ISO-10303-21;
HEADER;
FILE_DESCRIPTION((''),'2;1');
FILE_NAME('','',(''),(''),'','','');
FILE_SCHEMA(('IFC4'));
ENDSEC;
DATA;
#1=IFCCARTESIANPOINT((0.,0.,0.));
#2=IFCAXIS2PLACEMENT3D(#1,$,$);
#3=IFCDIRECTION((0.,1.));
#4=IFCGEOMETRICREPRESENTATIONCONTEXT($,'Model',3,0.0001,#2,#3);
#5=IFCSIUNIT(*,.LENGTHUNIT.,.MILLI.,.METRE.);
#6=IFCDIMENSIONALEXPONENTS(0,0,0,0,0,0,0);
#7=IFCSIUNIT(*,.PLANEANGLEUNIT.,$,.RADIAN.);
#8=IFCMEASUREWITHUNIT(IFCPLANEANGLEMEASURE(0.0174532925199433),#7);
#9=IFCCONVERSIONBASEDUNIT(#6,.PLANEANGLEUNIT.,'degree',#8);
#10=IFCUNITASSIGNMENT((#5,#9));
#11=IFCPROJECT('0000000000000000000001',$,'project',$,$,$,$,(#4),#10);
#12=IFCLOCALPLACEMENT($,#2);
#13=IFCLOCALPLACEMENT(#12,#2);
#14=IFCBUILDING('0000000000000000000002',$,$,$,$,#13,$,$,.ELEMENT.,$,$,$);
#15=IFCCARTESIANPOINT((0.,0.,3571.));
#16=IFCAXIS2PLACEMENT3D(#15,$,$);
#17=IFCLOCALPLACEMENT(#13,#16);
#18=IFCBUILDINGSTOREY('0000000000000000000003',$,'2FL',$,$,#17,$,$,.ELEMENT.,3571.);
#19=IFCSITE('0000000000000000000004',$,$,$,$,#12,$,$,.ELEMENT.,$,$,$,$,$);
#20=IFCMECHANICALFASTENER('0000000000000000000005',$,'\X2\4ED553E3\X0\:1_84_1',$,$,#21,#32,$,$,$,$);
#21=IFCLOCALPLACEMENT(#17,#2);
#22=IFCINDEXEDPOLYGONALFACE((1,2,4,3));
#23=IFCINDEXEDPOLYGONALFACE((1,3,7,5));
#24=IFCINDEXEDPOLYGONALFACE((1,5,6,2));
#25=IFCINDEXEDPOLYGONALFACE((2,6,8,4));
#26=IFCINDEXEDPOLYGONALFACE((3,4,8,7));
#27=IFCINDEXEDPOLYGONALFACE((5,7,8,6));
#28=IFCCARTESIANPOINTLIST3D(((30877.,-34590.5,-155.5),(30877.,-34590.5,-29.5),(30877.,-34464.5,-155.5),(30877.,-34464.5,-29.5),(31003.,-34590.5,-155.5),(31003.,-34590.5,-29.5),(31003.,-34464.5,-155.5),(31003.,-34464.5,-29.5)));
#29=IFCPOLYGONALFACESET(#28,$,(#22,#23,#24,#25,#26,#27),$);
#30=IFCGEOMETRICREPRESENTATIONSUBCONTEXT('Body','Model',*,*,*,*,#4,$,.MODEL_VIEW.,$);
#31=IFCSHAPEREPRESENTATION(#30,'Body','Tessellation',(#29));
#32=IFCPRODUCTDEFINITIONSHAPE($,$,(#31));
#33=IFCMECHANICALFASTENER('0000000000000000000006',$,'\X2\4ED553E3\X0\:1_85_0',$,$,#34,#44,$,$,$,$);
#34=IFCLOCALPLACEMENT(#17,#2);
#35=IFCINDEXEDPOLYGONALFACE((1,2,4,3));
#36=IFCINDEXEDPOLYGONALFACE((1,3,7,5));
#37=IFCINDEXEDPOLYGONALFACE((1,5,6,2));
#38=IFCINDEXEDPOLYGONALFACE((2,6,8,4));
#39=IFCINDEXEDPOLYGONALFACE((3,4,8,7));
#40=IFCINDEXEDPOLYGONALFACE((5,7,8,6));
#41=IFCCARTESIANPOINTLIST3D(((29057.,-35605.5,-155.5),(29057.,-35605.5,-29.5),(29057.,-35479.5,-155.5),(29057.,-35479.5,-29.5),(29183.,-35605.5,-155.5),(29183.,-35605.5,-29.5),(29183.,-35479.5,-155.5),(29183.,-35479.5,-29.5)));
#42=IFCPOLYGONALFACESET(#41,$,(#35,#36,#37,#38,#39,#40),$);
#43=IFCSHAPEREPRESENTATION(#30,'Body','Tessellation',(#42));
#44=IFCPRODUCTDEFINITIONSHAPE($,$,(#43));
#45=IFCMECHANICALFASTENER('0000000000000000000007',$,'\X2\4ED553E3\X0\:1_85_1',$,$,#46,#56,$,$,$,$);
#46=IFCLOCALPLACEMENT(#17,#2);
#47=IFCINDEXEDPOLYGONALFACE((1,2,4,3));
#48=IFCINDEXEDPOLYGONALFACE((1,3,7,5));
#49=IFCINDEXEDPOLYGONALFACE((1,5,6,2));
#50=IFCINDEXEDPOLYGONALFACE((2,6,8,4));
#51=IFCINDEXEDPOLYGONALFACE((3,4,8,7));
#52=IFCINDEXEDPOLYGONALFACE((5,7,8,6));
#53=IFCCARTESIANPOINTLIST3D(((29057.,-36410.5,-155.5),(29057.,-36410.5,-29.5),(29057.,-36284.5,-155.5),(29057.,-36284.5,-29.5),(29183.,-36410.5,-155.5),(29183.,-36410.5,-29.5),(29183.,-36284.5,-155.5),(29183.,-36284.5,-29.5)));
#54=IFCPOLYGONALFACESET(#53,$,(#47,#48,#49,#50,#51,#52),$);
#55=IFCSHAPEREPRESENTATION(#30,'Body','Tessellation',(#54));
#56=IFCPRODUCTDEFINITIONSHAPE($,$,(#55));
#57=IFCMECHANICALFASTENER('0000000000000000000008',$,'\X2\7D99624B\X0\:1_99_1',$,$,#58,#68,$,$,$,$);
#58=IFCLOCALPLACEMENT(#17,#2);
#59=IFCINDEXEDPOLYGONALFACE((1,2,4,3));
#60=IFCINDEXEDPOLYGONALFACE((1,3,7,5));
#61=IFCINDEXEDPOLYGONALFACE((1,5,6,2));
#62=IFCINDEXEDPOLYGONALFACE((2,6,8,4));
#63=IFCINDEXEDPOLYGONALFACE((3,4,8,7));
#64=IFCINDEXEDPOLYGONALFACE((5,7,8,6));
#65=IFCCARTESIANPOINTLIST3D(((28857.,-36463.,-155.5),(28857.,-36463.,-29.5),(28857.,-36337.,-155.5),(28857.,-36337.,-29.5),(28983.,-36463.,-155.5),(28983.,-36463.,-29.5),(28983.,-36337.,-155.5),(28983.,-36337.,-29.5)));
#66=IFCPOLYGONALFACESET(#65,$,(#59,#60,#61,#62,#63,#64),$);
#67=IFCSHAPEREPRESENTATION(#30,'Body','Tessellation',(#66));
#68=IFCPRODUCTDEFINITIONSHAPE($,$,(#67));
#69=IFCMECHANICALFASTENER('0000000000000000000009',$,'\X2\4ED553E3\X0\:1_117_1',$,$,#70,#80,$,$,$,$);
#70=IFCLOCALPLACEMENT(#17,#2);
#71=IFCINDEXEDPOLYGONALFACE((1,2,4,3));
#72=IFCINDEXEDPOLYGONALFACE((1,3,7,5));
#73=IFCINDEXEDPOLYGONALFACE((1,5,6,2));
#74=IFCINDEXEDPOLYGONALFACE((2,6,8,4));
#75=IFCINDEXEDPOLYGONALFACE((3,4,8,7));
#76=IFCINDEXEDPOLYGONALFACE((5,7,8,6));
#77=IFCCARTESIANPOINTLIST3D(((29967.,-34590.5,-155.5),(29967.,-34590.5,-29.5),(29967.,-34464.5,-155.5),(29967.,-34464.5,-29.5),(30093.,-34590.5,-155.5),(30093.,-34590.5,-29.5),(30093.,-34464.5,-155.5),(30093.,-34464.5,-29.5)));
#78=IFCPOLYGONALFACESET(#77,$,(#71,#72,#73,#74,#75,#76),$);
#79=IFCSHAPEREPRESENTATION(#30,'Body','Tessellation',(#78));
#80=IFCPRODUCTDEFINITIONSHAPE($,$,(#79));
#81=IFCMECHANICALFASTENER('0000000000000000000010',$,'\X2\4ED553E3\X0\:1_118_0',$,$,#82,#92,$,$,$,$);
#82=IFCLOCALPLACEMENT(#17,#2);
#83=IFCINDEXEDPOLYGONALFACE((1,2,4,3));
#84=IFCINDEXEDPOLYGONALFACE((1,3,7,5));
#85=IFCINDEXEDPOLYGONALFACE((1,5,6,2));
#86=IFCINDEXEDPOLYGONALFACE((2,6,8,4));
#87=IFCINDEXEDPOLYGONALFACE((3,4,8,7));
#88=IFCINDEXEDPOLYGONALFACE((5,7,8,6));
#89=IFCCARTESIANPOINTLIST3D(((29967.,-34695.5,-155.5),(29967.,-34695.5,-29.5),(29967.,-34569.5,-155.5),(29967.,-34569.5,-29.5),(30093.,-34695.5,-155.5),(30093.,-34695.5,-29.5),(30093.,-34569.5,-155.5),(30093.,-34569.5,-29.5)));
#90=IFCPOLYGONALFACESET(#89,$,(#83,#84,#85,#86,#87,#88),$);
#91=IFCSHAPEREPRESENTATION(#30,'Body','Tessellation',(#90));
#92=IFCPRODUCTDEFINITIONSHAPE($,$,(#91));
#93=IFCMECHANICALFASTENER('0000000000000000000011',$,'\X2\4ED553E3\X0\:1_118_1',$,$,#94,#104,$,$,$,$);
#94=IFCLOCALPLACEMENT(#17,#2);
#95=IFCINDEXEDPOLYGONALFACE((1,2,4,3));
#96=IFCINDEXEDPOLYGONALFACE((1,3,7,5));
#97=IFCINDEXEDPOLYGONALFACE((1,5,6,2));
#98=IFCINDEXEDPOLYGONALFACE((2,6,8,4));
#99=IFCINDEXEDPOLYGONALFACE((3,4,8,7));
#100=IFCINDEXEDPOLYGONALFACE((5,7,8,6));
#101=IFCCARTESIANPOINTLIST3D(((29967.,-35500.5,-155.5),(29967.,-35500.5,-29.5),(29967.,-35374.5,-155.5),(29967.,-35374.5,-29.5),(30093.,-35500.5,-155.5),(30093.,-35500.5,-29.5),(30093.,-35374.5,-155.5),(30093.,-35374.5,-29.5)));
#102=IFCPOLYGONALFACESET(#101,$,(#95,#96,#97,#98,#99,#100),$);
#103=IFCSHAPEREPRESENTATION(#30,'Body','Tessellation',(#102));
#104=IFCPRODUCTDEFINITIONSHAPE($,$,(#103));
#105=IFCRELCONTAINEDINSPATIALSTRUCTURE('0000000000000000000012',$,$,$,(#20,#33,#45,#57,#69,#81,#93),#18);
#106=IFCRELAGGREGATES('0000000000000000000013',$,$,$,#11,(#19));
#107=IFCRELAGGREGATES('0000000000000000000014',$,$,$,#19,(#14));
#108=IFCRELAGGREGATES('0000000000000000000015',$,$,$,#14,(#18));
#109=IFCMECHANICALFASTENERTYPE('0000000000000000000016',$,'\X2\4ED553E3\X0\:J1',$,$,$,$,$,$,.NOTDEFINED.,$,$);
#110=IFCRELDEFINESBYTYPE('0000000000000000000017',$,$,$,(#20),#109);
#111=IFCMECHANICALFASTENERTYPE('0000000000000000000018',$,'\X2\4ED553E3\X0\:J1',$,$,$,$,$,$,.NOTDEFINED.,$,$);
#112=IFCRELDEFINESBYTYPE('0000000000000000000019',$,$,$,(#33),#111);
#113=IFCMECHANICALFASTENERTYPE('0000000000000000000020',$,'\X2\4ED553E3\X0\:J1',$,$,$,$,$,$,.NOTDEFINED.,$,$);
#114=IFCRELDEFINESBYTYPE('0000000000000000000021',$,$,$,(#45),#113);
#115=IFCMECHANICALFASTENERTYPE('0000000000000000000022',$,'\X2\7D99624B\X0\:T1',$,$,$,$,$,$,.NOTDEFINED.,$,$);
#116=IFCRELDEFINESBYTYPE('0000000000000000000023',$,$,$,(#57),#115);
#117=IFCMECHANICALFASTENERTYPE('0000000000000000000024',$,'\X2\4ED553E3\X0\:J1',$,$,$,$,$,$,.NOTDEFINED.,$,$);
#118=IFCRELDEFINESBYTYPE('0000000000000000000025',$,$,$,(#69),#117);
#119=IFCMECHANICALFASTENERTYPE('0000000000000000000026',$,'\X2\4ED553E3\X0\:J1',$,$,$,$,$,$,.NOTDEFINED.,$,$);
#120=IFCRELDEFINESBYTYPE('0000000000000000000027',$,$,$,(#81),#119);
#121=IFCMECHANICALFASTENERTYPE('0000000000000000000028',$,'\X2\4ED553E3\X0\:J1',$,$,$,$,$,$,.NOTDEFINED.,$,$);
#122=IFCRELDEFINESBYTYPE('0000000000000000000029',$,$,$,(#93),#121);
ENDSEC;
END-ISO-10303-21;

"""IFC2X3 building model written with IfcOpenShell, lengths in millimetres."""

from ifc_helpers import new_model, entity, si_unit, converted_unit, direction, frame, origin, origin_with_axes, origin_2d, place, context, subcontext, project, spatial, rectangle, extrude, type_object, element, save


model = new_model("IFC2X3")

# Units and contexts
model_context = context("Model", 3, precision=0.0001, world=origin(), true_north=direction((0.0, 1.0)))
body_context = subcontext(model_context, "Body", "Model", "MODEL_VIEW")
ifc_project = project(units=[si_unit("LENGTHUNIT", "METRE", prefix="MILLI"), converted_unit("PLANEANGLEUNIT", "degree", entity("IfcPlaneAngleMeasure", 0.0174532925199433), si_unit("PLANEANGLEUNIT", "RADIAN"), dimensions=[0, 0, 0, 0, 0, 0, 0])], contexts=[model_context])

# Site, building, storey
site_placement = place(None, origin())
site = spatial("IfcSite", under=ifc_project, at=site_placement, CompositionType="ELEMENT")
building_placement = place(site_placement, origin())
building = spatial("IfcBuilding", under=site, at=building_placement, CompositionType="ELEMENT")
storey_placement = place(building_placement, frame((0.0, 0.0, 3571.0)))
storey = spatial("IfcBuildingStorey", under=building, at=storey_placement, Name="2FL", CompositionType="ELEMENT", Elevation=3571.0)

# Mechanical fasteners
mechanical_fastener_type_1 = type_object("IfcMechanicalFastenerType", Name="仕口:J1")
mechanical_fastener_1_placement = place(storey_placement, frame((30940.0, -34527.5, -155.5)))
element("IfcMechanicalFastener", 1, at=mechanical_fastener_1_placement, inside=storey, type_object=mechanical_fastener_type_1, Name="仕口:1_84_1", context=body_context, shape_type="SweptSolid", body=[
    extrude(rectangle(XDim=126.0, YDim=126.0, at=origin_2d()), origin_with_axes(), (0.0, 0.0, 1.0), 126.0),
])
mechanical_fastener_type_2 = type_object("IfcMechanicalFastenerType", Name="仕口:J1")
mechanical_fastener_2_placement = place(storey_placement, frame((29120.0, -35542.5, -155.5)))
element("IfcMechanicalFastener", 2, at=mechanical_fastener_2_placement, inside=storey, type_object=mechanical_fastener_type_2, Name="仕口:1_85_0", context=body_context, shape_type="SweptSolid", body=[
    extrude(rectangle(XDim=126.0, YDim=126.0, at=origin_2d()), origin_with_axes(), (0.0, 0.0, 1.0), 126.0),
])
mechanical_fastener_type_3 = type_object("IfcMechanicalFastenerType", Name="仕口:J1")
mechanical_fastener_3_placement = place(storey_placement, frame((29120.0, -36347.5, -155.5)))
element("IfcMechanicalFastener", 3, at=mechanical_fastener_3_placement, inside=storey, type_object=mechanical_fastener_type_3, Name="仕口:1_85_1", context=body_context, shape_type="SweptSolid", body=[
    extrude(rectangle(XDim=126.0, YDim=126.0, at=origin_2d()), origin_with_axes(), (0.0, 0.0, 1.0), 126.0),
])
mechanical_fastener_type_4 = type_object("IfcMechanicalFastenerType", Name="継手:T1")
mechanical_fastener_4_placement = place(storey_placement, frame((28920.0, -36400.0, -155.5)))
element("IfcMechanicalFastener", 4, at=mechanical_fastener_4_placement, inside=storey, type_object=mechanical_fastener_type_4, Name="継手:1_99_1", context=body_context, shape_type="SweptSolid", body=[
    extrude(rectangle(XDim=126.0, YDim=126.0, at=origin_2d()), origin_with_axes(), (0.0, 0.0, 1.0), 126.0),
])
mechanical_fastener_type_5 = type_object("IfcMechanicalFastenerType", Name="仕口:J1")
mechanical_fastener_5_placement = place(storey_placement, frame((30030.0, -34527.5, -155.5)))
element("IfcMechanicalFastener", 5, at=mechanical_fastener_5_placement, inside=storey, type_object=mechanical_fastener_type_5, Name="仕口:1_117_1", context=body_context, shape_type="SweptSolid", body=[
    extrude(rectangle(XDim=126.0, YDim=126.0, at=origin_2d()), origin_with_axes(), (0.0, 0.0, 1.0), 126.0),
])
mechanical_fastener_type_6 = type_object("IfcMechanicalFastenerType", Name="仕口:J1")
mechanical_fastener_6_placement = place(storey_placement, frame((30030.0, -34632.5, -155.5)))
element("IfcMechanicalFastener", 6, at=mechanical_fastener_6_placement, inside=storey, type_object=mechanical_fastener_type_6, Name="仕口:1_118_0", context=body_context, shape_type="SweptSolid", body=[
    extrude(rectangle(XDim=126.0, YDim=126.0, at=origin_2d()), origin_with_axes(), (0.0, 0.0, 1.0), 126.0),
])
mechanical_fastener_type_7 = type_object("IfcMechanicalFastenerType", Name="仕口:J1")
mechanical_fastener_7_placement = place(storey_placement, frame((30030.0, -35437.5, -155.5)))
element("IfcMechanicalFastener", 7, at=mechanical_fastener_7_placement, inside=storey, type_object=mechanical_fastener_type_7, Name="仕口:1_118_1", context=body_context, shape_type="SweptSolid", body=[
    extrude(rectangle(XDim=126.0, YDim=126.0, at=origin_2d()), origin_with_axes(), (0.0, 0.0, 1.0), 126.0),
])

save(model, "model.ifc")
